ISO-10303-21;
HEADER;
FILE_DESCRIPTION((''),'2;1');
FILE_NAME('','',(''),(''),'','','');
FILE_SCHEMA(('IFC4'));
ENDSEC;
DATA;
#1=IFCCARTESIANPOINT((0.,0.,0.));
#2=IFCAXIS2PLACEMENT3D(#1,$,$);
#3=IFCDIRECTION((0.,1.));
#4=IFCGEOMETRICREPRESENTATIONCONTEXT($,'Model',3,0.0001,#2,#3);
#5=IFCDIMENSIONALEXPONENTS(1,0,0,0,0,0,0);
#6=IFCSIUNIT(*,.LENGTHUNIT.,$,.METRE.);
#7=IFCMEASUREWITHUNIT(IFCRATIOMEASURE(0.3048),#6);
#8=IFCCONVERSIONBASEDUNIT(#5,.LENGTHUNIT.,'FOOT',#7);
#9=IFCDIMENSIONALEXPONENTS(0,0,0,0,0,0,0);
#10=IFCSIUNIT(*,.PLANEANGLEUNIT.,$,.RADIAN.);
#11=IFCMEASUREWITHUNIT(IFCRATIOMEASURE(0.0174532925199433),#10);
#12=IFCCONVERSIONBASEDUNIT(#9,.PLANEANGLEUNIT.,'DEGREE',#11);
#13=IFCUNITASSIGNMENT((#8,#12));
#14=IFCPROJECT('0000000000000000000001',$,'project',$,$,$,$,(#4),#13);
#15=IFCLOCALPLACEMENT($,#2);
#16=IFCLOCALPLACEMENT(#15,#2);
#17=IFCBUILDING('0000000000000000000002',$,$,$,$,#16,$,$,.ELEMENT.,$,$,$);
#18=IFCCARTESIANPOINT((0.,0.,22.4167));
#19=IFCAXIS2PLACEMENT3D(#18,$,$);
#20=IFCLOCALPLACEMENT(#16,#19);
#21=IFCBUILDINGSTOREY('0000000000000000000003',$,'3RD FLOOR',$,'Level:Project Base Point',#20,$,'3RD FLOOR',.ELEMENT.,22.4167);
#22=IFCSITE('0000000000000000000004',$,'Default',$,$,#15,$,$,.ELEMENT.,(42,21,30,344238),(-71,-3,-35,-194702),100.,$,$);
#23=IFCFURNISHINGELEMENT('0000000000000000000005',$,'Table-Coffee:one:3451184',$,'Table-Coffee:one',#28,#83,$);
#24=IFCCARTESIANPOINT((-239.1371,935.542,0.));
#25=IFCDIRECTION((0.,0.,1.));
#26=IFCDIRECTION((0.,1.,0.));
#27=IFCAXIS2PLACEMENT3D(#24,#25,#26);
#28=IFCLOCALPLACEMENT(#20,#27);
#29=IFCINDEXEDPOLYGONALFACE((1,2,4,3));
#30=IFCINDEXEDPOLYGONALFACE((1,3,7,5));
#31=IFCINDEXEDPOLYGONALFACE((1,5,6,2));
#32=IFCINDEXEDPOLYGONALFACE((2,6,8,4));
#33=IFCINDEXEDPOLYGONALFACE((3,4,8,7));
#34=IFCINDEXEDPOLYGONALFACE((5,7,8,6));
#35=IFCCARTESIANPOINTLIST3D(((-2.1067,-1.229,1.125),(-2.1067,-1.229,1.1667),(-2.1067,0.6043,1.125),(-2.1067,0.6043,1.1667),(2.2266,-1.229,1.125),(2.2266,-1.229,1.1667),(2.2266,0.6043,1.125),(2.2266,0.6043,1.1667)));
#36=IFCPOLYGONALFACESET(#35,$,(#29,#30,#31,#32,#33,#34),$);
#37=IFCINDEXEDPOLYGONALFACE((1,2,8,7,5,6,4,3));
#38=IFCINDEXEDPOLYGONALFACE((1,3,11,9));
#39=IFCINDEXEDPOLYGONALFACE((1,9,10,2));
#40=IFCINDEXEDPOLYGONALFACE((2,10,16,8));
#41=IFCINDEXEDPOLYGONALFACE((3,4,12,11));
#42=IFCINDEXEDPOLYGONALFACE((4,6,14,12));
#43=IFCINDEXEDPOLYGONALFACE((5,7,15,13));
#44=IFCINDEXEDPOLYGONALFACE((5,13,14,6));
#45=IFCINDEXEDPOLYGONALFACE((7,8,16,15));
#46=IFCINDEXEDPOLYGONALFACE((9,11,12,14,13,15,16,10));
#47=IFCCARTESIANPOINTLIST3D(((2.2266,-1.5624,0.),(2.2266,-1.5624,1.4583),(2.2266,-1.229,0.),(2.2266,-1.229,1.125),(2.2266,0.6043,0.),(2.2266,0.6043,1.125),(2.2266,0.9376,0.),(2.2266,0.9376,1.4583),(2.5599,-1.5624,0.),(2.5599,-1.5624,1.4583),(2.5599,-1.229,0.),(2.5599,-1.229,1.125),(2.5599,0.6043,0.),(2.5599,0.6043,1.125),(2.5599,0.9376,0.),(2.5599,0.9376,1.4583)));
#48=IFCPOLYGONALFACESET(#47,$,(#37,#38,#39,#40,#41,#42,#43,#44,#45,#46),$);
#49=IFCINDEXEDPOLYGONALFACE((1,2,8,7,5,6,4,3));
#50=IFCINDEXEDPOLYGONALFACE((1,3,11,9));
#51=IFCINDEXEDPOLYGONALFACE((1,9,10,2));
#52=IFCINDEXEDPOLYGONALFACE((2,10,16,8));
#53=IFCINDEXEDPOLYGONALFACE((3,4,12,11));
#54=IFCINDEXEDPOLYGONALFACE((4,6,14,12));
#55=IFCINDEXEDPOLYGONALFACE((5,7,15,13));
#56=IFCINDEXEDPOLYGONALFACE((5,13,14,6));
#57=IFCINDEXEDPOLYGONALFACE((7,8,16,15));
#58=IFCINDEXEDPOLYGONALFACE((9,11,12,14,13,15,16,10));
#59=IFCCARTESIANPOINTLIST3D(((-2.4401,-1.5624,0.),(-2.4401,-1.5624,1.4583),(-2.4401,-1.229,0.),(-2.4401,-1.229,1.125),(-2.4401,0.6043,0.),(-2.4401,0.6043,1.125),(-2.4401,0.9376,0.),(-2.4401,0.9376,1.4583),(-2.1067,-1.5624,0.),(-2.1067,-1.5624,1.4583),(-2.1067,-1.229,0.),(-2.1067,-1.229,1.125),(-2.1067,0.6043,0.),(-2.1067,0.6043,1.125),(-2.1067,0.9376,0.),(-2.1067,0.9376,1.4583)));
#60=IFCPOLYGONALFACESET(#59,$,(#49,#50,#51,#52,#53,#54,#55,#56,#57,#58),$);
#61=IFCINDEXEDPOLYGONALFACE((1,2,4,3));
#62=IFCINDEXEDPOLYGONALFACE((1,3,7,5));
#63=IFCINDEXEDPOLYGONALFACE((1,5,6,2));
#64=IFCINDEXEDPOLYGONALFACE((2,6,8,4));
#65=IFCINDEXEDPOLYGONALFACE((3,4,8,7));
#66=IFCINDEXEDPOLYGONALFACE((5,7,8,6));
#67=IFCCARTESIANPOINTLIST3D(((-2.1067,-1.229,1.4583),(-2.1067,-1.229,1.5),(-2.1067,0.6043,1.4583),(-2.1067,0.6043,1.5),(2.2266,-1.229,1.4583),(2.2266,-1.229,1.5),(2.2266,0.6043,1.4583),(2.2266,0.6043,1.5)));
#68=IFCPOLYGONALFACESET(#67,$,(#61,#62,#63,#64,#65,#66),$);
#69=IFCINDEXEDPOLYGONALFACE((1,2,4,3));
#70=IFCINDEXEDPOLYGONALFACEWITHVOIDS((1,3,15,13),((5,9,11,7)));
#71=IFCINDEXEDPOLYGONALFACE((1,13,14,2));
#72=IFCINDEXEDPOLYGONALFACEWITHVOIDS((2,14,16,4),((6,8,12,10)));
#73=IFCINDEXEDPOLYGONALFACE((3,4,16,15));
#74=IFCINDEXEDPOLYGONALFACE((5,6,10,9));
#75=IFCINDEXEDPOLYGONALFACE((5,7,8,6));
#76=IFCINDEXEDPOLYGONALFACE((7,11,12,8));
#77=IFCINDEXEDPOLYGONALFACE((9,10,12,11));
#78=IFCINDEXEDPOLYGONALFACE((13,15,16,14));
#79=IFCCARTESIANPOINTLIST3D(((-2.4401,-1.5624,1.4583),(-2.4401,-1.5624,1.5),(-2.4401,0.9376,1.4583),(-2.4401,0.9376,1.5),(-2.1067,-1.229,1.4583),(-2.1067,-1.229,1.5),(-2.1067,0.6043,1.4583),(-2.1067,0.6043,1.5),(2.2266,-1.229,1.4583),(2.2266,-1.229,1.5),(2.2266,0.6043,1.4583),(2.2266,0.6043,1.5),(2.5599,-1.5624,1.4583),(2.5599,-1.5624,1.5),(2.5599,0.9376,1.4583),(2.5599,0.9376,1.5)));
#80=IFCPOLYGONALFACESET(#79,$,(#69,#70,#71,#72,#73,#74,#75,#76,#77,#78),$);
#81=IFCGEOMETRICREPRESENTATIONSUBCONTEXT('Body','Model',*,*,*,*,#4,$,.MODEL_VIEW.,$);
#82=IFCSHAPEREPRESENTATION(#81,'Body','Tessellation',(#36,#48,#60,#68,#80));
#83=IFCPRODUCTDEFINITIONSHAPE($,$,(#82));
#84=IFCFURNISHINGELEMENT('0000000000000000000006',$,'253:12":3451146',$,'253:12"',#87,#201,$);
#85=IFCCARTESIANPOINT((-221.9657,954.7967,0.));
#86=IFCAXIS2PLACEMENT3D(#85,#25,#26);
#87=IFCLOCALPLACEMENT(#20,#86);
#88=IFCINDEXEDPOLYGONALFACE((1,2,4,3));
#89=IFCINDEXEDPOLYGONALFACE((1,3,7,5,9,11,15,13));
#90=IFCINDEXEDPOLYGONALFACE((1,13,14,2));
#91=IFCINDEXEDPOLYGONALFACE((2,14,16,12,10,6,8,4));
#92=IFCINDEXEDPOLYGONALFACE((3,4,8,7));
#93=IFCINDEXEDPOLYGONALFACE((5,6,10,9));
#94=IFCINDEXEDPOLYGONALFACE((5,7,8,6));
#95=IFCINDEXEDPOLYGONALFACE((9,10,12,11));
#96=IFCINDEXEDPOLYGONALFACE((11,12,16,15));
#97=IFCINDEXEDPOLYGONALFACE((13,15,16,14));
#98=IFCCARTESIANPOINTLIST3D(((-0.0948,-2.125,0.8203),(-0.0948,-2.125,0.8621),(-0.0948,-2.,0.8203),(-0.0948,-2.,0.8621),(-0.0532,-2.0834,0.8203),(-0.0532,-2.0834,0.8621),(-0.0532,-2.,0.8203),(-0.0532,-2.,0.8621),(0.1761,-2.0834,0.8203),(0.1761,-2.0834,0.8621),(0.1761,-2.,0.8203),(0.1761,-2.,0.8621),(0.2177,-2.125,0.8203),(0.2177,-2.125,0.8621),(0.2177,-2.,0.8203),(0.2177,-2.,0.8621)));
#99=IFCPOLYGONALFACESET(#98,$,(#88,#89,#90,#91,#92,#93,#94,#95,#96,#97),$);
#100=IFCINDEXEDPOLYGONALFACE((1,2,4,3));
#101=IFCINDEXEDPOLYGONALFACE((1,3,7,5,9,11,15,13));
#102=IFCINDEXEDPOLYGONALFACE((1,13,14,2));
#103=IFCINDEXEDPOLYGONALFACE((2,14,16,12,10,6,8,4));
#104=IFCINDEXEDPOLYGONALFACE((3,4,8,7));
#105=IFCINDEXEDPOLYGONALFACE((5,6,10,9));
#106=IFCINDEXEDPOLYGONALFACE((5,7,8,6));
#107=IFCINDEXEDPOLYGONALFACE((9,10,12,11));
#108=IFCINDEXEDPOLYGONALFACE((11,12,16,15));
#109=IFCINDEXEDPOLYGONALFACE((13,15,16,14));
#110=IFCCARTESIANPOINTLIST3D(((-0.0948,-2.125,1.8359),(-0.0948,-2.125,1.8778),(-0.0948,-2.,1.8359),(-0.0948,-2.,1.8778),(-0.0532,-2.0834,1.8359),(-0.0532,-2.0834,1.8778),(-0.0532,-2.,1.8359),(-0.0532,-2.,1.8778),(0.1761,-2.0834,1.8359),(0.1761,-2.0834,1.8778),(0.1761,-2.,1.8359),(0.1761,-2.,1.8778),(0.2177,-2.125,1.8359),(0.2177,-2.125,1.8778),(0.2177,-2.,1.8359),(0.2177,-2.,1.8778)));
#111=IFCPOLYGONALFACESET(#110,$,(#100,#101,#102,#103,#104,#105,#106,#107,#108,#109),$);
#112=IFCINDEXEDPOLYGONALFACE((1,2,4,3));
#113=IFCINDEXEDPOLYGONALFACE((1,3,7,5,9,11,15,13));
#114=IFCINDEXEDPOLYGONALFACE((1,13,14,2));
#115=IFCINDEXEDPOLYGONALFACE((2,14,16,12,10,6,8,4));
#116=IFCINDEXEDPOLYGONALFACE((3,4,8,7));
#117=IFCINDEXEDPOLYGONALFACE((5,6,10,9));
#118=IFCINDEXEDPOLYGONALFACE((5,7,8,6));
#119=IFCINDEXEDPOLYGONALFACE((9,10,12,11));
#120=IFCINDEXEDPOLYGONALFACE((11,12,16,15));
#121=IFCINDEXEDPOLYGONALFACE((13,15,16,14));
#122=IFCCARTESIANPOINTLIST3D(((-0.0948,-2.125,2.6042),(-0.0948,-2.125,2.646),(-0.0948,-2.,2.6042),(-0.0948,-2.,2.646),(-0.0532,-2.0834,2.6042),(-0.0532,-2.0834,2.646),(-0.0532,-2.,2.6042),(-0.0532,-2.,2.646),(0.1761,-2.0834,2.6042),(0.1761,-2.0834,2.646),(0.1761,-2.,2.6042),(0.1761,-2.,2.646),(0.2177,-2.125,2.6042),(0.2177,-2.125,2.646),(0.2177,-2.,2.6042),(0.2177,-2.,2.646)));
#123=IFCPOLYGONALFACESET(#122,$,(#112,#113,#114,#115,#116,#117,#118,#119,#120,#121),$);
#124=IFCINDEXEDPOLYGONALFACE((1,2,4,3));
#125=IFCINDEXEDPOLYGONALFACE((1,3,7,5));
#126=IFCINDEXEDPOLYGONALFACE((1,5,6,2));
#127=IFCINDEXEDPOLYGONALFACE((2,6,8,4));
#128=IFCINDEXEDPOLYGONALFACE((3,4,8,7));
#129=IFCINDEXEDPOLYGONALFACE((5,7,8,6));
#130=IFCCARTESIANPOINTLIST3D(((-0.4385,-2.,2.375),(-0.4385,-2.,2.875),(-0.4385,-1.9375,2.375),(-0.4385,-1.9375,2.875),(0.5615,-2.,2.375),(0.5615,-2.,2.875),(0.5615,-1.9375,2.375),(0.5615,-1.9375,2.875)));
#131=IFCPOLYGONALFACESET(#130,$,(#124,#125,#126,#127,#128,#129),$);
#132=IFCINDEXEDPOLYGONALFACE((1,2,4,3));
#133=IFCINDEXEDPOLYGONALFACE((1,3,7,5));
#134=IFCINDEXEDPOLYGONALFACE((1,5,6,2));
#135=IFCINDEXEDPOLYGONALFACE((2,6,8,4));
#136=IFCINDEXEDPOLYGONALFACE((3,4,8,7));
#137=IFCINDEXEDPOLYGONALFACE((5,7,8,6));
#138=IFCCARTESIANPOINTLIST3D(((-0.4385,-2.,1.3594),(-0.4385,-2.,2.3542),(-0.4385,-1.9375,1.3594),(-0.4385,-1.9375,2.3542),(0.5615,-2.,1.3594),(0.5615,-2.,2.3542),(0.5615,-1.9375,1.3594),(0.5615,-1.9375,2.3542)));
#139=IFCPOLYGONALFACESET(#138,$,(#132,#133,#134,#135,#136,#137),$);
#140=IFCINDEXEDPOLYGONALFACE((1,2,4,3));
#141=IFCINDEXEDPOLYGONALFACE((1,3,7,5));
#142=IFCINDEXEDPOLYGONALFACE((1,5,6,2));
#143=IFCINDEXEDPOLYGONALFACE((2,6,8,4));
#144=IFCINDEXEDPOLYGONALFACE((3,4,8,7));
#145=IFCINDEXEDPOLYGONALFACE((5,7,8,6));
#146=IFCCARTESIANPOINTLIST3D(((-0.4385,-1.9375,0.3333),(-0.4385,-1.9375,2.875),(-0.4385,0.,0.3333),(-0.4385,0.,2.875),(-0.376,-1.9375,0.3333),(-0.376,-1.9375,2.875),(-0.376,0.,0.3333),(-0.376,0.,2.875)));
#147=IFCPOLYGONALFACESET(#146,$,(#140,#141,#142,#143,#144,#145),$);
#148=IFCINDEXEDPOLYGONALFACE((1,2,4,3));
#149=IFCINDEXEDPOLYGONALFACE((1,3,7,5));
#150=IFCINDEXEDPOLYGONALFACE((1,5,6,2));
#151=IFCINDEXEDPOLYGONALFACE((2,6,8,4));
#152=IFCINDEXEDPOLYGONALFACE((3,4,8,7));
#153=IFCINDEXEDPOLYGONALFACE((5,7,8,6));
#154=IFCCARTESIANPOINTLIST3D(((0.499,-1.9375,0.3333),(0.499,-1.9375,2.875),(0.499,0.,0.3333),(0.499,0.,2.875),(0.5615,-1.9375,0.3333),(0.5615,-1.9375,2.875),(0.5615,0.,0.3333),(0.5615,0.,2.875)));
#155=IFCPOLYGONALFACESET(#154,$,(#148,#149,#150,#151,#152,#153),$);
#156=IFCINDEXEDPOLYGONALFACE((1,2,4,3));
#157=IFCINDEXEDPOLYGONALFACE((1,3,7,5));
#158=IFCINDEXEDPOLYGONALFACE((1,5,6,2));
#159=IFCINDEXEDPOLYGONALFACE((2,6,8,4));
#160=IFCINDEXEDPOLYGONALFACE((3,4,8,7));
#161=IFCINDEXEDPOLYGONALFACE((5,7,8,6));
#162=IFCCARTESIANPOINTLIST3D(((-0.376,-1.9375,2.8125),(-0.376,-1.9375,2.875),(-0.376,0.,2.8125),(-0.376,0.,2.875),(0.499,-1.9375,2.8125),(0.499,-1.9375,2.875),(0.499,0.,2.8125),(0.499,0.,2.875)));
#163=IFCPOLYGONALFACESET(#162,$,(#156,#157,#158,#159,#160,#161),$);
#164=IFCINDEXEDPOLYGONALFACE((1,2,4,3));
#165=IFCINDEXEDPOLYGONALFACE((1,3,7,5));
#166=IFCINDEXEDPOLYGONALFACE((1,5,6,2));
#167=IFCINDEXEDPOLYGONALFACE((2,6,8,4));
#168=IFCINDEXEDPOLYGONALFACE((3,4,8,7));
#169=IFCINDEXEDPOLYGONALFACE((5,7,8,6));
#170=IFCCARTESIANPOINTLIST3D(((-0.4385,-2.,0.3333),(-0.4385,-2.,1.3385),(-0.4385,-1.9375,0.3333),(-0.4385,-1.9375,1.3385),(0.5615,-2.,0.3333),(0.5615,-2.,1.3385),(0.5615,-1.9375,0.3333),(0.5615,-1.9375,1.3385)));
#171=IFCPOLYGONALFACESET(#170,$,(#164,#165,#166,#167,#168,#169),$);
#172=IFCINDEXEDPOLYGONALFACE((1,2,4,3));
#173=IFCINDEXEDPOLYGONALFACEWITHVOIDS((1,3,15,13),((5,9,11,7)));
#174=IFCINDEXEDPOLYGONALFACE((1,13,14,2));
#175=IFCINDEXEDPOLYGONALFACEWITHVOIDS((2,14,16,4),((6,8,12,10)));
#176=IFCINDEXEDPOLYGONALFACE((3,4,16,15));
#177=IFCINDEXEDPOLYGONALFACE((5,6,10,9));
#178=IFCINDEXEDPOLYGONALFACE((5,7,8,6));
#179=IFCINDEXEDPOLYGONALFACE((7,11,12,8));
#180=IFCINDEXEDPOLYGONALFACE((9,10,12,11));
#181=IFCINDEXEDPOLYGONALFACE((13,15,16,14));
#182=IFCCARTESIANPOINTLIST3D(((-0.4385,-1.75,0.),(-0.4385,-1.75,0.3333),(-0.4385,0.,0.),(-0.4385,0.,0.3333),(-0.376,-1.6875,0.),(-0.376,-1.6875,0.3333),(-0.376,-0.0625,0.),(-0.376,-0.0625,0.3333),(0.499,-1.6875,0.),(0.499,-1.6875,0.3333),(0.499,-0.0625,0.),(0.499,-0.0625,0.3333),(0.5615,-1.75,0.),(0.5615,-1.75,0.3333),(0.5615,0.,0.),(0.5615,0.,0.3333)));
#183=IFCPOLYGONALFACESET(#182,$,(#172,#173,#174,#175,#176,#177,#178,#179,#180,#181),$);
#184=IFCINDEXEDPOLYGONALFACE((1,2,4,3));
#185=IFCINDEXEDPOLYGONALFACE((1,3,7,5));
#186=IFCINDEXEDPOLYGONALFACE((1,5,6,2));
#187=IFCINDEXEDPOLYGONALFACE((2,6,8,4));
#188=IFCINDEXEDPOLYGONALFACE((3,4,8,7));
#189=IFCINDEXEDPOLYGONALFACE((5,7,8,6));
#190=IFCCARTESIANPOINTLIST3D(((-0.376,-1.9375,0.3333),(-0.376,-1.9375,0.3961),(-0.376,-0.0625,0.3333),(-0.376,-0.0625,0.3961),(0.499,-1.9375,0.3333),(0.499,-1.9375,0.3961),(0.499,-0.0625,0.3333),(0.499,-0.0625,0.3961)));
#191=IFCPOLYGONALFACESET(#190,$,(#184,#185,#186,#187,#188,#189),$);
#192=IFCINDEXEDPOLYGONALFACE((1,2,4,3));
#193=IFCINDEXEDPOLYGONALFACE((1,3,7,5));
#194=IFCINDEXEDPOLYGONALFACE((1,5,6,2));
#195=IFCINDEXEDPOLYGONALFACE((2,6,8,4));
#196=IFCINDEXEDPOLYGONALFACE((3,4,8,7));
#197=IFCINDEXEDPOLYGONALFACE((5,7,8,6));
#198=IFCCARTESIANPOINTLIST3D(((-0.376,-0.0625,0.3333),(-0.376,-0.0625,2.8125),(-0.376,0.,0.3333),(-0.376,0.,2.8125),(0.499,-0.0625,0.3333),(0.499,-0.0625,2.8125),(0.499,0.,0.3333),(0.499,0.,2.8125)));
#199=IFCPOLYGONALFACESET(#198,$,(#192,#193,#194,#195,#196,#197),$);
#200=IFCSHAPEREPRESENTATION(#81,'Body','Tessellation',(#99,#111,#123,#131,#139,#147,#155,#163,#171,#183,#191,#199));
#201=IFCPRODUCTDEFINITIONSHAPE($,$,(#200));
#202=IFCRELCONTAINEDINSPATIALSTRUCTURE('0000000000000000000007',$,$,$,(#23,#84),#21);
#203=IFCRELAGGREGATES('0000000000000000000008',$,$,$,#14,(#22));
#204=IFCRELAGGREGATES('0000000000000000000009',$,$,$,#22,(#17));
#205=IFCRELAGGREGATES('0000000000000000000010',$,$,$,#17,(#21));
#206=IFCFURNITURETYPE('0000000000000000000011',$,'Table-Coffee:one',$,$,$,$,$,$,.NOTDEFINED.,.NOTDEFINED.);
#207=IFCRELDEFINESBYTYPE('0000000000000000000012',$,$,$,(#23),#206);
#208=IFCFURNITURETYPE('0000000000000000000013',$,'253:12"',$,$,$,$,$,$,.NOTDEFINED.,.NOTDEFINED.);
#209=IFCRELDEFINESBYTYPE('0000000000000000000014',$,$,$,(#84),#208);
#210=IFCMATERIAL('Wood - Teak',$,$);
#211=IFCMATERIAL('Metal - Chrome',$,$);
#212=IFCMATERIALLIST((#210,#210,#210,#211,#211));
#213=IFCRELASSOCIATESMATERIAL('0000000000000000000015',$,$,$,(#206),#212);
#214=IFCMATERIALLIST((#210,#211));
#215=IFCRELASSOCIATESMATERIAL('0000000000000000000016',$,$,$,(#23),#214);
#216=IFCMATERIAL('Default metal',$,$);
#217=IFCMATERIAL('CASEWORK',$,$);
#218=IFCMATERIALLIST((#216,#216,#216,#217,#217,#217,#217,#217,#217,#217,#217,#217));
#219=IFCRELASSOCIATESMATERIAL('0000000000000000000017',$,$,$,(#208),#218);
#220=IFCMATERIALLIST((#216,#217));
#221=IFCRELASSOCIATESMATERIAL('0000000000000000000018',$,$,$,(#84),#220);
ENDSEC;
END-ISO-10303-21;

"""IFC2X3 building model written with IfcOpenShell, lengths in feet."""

from ifc_helpers import new_model, entity, si_unit, converted_unit, direction, frame, frame_2d, origin, origin_2d_with_axis, place, context, subcontext, project, spatial, polyline, rectangle, outline, extrude, source, transform, mapped, material, material_list, type_object, type_shapes, element, save


model = new_model("IFC2X3")

# Units and contexts
model_context = context("Model", 3, precision=0.0001, world=origin(), true_north=direction((0.0, 1.0)))
body_context = subcontext(model_context, "Body", "Model", "MODEL_VIEW")
ifc_project = project(units=[converted_unit("LENGTHUNIT", "FOOT", entity("IfcRatioMeasure", 0.3048), si_unit("LENGTHUNIT", "METRE"), dimensions=[1, 0, 0, 0, 0, 0, 0]), converted_unit("PLANEANGLEUNIT", "DEGREE", entity("IfcRatioMeasure", 0.0174532925199433), si_unit("PLANEANGLEUNIT", "RADIAN"), dimensions=[0, 0, 0, 0, 0, 0, 0])], contexts=[model_context])

# Site, building, storey
site_placement = place(None, origin())
site = spatial("IfcSite", under=ifc_project, at=site_placement, Name="Default", CompositionType="ELEMENT", RefLatitude=(42, 21, 30, 344238), RefLongitude=(-71, -3, -35, -194702), RefElevation=100.0)
building_placement = place(site_placement, origin())
building = spatial("IfcBuilding", under=site, at=building_placement, CompositionType="ELEMENT")
storey_placement = place(building_placement, frame((0.0, 0.0, 22.4167)))
storey = spatial("IfcBuildingStorey", under=building, at=storey_placement, Name="3RD FLOOR", ObjectType="Level:Project Base Point", LongName="3RD FLOOR", CompositionType="ELEMENT", Elevation=22.4167)

# Furnishing elements
ifc_material_1 = material(Name="Metal - Chrome")
ifc_material_2 = material(Name="Default metal")
ifc_material_3 = material(Name="CASEWORK")
ifc_material_4 = material(Name="Wood - Teak")
ifc_material_list_1 = material_list([ifc_material_4, ifc_material_1])
ifc_material_list_2 = material_list([ifc_material_4, ifc_material_4, ifc_material_4, ifc_material_1, ifc_material_1])
furniture_type_1 = type_object("IfcFurnitureType", Name="Table-Coffee:one", material=ifc_material_list_2)
shared_shape_1 = source(origin(), body_context, "Body", "SweptSolid", [
    extrude(rectangle(XDim=1.8333, YDim=4.3333, at=origin_2d_with_axis()), frame((0.0599, -0.3124, 1.125), z_axis=(0.0, 0.0, 1.0), x_axis=(0.0, 1.0, 0.0)), (0.0, 0.0, 1.0), 0.0417),
    extrude(outline(polyline([(-1.25, -0.6458), (-0.9167, -0.6458), (-0.9167, 0.4792), (0.9167, 0.4792), (0.9167, -0.6458), (1.25, -0.6458), (1.25, 0.8125), (-1.25, 0.8125), (-1.25, -0.6458)])), frame((2.2266, -0.3124, 0.6458), z_axis=(1.0, 0.0, 0.0), x_axis=(0.0, 1.0, 0.0)), (0.0, 0.0, 1.0), 0.3333),
    extrude(outline(polyline([(-0.8125, -1.25), (0.6458, -1.25), (0.6458, -0.9167), (-0.4792, -0.9167), (-0.4792, 0.9167), (0.6458, 0.9167), (0.6458, 1.25), (-0.8125, 1.25), (-0.8125, -1.25)])), frame((-2.4401, -0.3124, 0.6458), z_axis=(1.0, 0.0, 0.0), x_axis=(0.0, 0.0, -1.0)), (0.0, 0.0, 1.0), 0.3333),
    extrude(rectangle(XDim=1.8333, YDim=4.3333, at=origin_2d_with_axis()), frame((0.0599, -0.3124, 1.4583), z_axis=(0.0, 0.0, 1.0), x_axis=(0.0, 1.0, 0.0)), (0.0, 0.0, 1.0), 0.0417),
    extrude(outline(polyline([(-1.25, -2.5), (1.25, -2.5), (1.25, 2.5), (-1.25, 2.5), (-1.25, -2.5)]), holes=[polyline([(-0.9167, -2.1667), (-0.9167, 2.1667), (0.9167, 2.1667), (0.9167, -2.1667), (-0.9167, -2.1667)])]), frame((0.0599, -0.3124, 1.4583), z_axis=(0.0, 0.0, 1.0), x_axis=(0.0, 1.0, 0.0)), (0.0, 0.0, 1.0), 0.0417),
])
type_shapes(furniture_type_1, [shared_shape_1])
furnishing_1_placement = place(storey_placement, frame((-239.1371, 935.542, 0.0), z_axis=(0.0, 0.0, 1.0), x_axis=(0.0, 1.0, 0.0)))
element("IfcFurnishingElement", 1, at=furnishing_1_placement, inside=storey, type_object=furniture_type_1, material=ifc_material_list_1, Name="Table-Coffee:one:3451184", ObjectType="Table-Coffee:one", context=body_context, shape_type="MappedRepresentation", body=[
    mapped(shared_shape_1, transform((0.0, 0.0, 0.0), scale=1.0)),
])
ifc_material_list_3 = material_list([ifc_material_2, ifc_material_3])
ifc_material_list_4 = material_list([ifc_material_2, ifc_material_2, ifc_material_2, ifc_material_3, ifc_material_3, ifc_material_3, ifc_material_3, ifc_material_3, ifc_material_3, ifc_material_3, ifc_material_3, ifc_material_3])
furniture_type_2 = type_object("IfcFurnitureType", Name="253:12\"", material=ifc_material_list_4)
shared_shape_2 = source(origin(), body_context, "Body", "SweptSolid", [
    extrude(outline(polyline([(-0.0521, -0.1562), (0.0729, -0.1562), (0.0729, 0.1562), (-0.0521, 0.1562), (-0.0521, 0.1146), (0.0313, 0.1146), (0.0313, -0.1146), (-0.0521, -0.1146), (-0.0521, -0.1562)])), frame((0.0615, -2.0521, 0.8203), z_axis=(0.0, 0.0, 1.0), x_axis=(0.0, -1.0, 0.0)), (0.0, 0.0, 1.0), 0.0418),
    extrude(outline(polyline([(-0.0521, -0.1562), (0.0729, -0.1562), (0.0729, 0.1562), (-0.0521, 0.1562), (-0.0521, 0.1146), (0.0313, 0.1146), (0.0313, -0.1146), (-0.0521, -0.1146), (-0.0521, -0.1562)])), frame((0.0615, -2.0521, 1.8359), z_axis=(0.0, 0.0, 1.0), x_axis=(0.0, -1.0, 0.0)), (0.0, 0.0, 1.0), 0.0418),
    extrude(outline(polyline([(-0.0521, -0.1562), (0.0729, -0.1562), (0.0729, 0.1562), (-0.0521, 0.1562), (-0.0521, 0.1146), (0.0313, 0.1146), (0.0313, -0.1146), (-0.0521, -0.1146), (-0.0521, -0.1562)])), frame((0.0615, -2.0521, 2.6042), z_axis=(0.0, 0.0, 1.0), x_axis=(0.0, -1.0, 0.0)), (0.0, 0.0, 1.0), 0.0418),
    extrude(rectangle(XDim=0.0625, YDim=1.0, at=origin_2d_with_axis()), frame((0.0615, -1.9688, 2.375), z_axis=(0.0, 0.0, 1.0), x_axis=(0.0, 1.0, 0.0)), (0.0, 0.0, 1.0), 0.5),
    extrude(rectangle(XDim=0.0625, YDim=1.0, at=origin_2d_with_axis()), frame((0.0615, -1.9688, 1.3594), z_axis=(0.0, 0.0, 1.0), x_axis=(0.0, 1.0, 0.0)), (0.0, 0.0, 1.0), 0.9948),
    extrude(rectangle(XDim=0.0625, YDim=1.9375, at=frame_2d((0.0, 0.0), x_axis=(1.0, 0.0))), frame((-0.4073, -0.9687, 0.3333)), (0.0, 0.0, 1.0), 2.5417),
    extrude(rectangle(XDim=0.0625, YDim=1.9375, at=frame_2d((0.0, 0.0), x_axis=(1.0, 0.0))), frame((0.5302, -0.9687, 0.3333)), (0.0, 0.0, 1.0), 2.5417),
    extrude(rectangle(XDim=0.875, YDim=1.9375, at=origin_2d_with_axis()), frame((0.0615, -0.9688, 2.8125), z_axis=(0.0, 0.0, 1.0), x_axis=(-1.0, 0.0, 0.0)), (0.0, 0.0, 1.0), 0.0625),
    extrude(rectangle(XDim=0.0625, YDim=1.0, at=origin_2d_with_axis()), frame((0.0615, -1.9688, 0.3333), z_axis=(0.0, 0.0, 1.0), x_axis=(0.0, 1.0, 0.0)), (0.0, 0.0, 1.0), 1.0052),
    extrude(outline(polyline([(-0.5, -0.875), (0.5, -0.875), (0.5, 0.875), (-0.5, 0.875), (-0.5, -0.875)]), holes=[polyline([(-0.4375, -0.8125), (-0.4375, 0.8125), (0.4375, 0.8125), (0.4375, -0.8125), (-0.4375, -0.8125)])]), frame((0.0615, -0.875, 0.0)), (0.0, 0.0, 1.0), 0.3333),
    extrude(rectangle(XDim=0.875, YDim=1.875, at=frame_2d((0.0, 0.0), x_axis=(1.0, 0.0))), frame((0.0615, -1.0, 0.3333), z_axis=(0.0, 0.0, 1.0), x_axis=(-1.0, 0.0, 0.0)), (0.0, 0.0, 1.0), 0.0627),
    extrude(rectangle(XDim=0.0625, YDim=0.875, at=origin_2d_with_axis()), frame((0.0615, -0.0312, 0.3333), z_axis=(0.0, 0.0, 1.0), x_axis=(0.0, 1.0, 0.0)), (0.0, 0.0, 1.0), 2.4792),
])
type_shapes(furniture_type_2, [shared_shape_2])
furnishing_2_placement = place(storey_placement, frame((-221.9657, 954.7967, 0.0), z_axis=(0.0, 0.0, 1.0), x_axis=(0.0, 1.0, 0.0)))
element("IfcFurnishingElement", 2, at=furnishing_2_placement, inside=storey, type_object=furniture_type_2, material=ifc_material_list_3, Name="253:12\":3451146", ObjectType="253:12\"", context=body_context, shape_type="MappedRepresentation", body=[
    mapped(shared_shape_2, transform((0.0, 0.0, 0.0), scale=1.0)),
])

save(model, "model.ifc")
